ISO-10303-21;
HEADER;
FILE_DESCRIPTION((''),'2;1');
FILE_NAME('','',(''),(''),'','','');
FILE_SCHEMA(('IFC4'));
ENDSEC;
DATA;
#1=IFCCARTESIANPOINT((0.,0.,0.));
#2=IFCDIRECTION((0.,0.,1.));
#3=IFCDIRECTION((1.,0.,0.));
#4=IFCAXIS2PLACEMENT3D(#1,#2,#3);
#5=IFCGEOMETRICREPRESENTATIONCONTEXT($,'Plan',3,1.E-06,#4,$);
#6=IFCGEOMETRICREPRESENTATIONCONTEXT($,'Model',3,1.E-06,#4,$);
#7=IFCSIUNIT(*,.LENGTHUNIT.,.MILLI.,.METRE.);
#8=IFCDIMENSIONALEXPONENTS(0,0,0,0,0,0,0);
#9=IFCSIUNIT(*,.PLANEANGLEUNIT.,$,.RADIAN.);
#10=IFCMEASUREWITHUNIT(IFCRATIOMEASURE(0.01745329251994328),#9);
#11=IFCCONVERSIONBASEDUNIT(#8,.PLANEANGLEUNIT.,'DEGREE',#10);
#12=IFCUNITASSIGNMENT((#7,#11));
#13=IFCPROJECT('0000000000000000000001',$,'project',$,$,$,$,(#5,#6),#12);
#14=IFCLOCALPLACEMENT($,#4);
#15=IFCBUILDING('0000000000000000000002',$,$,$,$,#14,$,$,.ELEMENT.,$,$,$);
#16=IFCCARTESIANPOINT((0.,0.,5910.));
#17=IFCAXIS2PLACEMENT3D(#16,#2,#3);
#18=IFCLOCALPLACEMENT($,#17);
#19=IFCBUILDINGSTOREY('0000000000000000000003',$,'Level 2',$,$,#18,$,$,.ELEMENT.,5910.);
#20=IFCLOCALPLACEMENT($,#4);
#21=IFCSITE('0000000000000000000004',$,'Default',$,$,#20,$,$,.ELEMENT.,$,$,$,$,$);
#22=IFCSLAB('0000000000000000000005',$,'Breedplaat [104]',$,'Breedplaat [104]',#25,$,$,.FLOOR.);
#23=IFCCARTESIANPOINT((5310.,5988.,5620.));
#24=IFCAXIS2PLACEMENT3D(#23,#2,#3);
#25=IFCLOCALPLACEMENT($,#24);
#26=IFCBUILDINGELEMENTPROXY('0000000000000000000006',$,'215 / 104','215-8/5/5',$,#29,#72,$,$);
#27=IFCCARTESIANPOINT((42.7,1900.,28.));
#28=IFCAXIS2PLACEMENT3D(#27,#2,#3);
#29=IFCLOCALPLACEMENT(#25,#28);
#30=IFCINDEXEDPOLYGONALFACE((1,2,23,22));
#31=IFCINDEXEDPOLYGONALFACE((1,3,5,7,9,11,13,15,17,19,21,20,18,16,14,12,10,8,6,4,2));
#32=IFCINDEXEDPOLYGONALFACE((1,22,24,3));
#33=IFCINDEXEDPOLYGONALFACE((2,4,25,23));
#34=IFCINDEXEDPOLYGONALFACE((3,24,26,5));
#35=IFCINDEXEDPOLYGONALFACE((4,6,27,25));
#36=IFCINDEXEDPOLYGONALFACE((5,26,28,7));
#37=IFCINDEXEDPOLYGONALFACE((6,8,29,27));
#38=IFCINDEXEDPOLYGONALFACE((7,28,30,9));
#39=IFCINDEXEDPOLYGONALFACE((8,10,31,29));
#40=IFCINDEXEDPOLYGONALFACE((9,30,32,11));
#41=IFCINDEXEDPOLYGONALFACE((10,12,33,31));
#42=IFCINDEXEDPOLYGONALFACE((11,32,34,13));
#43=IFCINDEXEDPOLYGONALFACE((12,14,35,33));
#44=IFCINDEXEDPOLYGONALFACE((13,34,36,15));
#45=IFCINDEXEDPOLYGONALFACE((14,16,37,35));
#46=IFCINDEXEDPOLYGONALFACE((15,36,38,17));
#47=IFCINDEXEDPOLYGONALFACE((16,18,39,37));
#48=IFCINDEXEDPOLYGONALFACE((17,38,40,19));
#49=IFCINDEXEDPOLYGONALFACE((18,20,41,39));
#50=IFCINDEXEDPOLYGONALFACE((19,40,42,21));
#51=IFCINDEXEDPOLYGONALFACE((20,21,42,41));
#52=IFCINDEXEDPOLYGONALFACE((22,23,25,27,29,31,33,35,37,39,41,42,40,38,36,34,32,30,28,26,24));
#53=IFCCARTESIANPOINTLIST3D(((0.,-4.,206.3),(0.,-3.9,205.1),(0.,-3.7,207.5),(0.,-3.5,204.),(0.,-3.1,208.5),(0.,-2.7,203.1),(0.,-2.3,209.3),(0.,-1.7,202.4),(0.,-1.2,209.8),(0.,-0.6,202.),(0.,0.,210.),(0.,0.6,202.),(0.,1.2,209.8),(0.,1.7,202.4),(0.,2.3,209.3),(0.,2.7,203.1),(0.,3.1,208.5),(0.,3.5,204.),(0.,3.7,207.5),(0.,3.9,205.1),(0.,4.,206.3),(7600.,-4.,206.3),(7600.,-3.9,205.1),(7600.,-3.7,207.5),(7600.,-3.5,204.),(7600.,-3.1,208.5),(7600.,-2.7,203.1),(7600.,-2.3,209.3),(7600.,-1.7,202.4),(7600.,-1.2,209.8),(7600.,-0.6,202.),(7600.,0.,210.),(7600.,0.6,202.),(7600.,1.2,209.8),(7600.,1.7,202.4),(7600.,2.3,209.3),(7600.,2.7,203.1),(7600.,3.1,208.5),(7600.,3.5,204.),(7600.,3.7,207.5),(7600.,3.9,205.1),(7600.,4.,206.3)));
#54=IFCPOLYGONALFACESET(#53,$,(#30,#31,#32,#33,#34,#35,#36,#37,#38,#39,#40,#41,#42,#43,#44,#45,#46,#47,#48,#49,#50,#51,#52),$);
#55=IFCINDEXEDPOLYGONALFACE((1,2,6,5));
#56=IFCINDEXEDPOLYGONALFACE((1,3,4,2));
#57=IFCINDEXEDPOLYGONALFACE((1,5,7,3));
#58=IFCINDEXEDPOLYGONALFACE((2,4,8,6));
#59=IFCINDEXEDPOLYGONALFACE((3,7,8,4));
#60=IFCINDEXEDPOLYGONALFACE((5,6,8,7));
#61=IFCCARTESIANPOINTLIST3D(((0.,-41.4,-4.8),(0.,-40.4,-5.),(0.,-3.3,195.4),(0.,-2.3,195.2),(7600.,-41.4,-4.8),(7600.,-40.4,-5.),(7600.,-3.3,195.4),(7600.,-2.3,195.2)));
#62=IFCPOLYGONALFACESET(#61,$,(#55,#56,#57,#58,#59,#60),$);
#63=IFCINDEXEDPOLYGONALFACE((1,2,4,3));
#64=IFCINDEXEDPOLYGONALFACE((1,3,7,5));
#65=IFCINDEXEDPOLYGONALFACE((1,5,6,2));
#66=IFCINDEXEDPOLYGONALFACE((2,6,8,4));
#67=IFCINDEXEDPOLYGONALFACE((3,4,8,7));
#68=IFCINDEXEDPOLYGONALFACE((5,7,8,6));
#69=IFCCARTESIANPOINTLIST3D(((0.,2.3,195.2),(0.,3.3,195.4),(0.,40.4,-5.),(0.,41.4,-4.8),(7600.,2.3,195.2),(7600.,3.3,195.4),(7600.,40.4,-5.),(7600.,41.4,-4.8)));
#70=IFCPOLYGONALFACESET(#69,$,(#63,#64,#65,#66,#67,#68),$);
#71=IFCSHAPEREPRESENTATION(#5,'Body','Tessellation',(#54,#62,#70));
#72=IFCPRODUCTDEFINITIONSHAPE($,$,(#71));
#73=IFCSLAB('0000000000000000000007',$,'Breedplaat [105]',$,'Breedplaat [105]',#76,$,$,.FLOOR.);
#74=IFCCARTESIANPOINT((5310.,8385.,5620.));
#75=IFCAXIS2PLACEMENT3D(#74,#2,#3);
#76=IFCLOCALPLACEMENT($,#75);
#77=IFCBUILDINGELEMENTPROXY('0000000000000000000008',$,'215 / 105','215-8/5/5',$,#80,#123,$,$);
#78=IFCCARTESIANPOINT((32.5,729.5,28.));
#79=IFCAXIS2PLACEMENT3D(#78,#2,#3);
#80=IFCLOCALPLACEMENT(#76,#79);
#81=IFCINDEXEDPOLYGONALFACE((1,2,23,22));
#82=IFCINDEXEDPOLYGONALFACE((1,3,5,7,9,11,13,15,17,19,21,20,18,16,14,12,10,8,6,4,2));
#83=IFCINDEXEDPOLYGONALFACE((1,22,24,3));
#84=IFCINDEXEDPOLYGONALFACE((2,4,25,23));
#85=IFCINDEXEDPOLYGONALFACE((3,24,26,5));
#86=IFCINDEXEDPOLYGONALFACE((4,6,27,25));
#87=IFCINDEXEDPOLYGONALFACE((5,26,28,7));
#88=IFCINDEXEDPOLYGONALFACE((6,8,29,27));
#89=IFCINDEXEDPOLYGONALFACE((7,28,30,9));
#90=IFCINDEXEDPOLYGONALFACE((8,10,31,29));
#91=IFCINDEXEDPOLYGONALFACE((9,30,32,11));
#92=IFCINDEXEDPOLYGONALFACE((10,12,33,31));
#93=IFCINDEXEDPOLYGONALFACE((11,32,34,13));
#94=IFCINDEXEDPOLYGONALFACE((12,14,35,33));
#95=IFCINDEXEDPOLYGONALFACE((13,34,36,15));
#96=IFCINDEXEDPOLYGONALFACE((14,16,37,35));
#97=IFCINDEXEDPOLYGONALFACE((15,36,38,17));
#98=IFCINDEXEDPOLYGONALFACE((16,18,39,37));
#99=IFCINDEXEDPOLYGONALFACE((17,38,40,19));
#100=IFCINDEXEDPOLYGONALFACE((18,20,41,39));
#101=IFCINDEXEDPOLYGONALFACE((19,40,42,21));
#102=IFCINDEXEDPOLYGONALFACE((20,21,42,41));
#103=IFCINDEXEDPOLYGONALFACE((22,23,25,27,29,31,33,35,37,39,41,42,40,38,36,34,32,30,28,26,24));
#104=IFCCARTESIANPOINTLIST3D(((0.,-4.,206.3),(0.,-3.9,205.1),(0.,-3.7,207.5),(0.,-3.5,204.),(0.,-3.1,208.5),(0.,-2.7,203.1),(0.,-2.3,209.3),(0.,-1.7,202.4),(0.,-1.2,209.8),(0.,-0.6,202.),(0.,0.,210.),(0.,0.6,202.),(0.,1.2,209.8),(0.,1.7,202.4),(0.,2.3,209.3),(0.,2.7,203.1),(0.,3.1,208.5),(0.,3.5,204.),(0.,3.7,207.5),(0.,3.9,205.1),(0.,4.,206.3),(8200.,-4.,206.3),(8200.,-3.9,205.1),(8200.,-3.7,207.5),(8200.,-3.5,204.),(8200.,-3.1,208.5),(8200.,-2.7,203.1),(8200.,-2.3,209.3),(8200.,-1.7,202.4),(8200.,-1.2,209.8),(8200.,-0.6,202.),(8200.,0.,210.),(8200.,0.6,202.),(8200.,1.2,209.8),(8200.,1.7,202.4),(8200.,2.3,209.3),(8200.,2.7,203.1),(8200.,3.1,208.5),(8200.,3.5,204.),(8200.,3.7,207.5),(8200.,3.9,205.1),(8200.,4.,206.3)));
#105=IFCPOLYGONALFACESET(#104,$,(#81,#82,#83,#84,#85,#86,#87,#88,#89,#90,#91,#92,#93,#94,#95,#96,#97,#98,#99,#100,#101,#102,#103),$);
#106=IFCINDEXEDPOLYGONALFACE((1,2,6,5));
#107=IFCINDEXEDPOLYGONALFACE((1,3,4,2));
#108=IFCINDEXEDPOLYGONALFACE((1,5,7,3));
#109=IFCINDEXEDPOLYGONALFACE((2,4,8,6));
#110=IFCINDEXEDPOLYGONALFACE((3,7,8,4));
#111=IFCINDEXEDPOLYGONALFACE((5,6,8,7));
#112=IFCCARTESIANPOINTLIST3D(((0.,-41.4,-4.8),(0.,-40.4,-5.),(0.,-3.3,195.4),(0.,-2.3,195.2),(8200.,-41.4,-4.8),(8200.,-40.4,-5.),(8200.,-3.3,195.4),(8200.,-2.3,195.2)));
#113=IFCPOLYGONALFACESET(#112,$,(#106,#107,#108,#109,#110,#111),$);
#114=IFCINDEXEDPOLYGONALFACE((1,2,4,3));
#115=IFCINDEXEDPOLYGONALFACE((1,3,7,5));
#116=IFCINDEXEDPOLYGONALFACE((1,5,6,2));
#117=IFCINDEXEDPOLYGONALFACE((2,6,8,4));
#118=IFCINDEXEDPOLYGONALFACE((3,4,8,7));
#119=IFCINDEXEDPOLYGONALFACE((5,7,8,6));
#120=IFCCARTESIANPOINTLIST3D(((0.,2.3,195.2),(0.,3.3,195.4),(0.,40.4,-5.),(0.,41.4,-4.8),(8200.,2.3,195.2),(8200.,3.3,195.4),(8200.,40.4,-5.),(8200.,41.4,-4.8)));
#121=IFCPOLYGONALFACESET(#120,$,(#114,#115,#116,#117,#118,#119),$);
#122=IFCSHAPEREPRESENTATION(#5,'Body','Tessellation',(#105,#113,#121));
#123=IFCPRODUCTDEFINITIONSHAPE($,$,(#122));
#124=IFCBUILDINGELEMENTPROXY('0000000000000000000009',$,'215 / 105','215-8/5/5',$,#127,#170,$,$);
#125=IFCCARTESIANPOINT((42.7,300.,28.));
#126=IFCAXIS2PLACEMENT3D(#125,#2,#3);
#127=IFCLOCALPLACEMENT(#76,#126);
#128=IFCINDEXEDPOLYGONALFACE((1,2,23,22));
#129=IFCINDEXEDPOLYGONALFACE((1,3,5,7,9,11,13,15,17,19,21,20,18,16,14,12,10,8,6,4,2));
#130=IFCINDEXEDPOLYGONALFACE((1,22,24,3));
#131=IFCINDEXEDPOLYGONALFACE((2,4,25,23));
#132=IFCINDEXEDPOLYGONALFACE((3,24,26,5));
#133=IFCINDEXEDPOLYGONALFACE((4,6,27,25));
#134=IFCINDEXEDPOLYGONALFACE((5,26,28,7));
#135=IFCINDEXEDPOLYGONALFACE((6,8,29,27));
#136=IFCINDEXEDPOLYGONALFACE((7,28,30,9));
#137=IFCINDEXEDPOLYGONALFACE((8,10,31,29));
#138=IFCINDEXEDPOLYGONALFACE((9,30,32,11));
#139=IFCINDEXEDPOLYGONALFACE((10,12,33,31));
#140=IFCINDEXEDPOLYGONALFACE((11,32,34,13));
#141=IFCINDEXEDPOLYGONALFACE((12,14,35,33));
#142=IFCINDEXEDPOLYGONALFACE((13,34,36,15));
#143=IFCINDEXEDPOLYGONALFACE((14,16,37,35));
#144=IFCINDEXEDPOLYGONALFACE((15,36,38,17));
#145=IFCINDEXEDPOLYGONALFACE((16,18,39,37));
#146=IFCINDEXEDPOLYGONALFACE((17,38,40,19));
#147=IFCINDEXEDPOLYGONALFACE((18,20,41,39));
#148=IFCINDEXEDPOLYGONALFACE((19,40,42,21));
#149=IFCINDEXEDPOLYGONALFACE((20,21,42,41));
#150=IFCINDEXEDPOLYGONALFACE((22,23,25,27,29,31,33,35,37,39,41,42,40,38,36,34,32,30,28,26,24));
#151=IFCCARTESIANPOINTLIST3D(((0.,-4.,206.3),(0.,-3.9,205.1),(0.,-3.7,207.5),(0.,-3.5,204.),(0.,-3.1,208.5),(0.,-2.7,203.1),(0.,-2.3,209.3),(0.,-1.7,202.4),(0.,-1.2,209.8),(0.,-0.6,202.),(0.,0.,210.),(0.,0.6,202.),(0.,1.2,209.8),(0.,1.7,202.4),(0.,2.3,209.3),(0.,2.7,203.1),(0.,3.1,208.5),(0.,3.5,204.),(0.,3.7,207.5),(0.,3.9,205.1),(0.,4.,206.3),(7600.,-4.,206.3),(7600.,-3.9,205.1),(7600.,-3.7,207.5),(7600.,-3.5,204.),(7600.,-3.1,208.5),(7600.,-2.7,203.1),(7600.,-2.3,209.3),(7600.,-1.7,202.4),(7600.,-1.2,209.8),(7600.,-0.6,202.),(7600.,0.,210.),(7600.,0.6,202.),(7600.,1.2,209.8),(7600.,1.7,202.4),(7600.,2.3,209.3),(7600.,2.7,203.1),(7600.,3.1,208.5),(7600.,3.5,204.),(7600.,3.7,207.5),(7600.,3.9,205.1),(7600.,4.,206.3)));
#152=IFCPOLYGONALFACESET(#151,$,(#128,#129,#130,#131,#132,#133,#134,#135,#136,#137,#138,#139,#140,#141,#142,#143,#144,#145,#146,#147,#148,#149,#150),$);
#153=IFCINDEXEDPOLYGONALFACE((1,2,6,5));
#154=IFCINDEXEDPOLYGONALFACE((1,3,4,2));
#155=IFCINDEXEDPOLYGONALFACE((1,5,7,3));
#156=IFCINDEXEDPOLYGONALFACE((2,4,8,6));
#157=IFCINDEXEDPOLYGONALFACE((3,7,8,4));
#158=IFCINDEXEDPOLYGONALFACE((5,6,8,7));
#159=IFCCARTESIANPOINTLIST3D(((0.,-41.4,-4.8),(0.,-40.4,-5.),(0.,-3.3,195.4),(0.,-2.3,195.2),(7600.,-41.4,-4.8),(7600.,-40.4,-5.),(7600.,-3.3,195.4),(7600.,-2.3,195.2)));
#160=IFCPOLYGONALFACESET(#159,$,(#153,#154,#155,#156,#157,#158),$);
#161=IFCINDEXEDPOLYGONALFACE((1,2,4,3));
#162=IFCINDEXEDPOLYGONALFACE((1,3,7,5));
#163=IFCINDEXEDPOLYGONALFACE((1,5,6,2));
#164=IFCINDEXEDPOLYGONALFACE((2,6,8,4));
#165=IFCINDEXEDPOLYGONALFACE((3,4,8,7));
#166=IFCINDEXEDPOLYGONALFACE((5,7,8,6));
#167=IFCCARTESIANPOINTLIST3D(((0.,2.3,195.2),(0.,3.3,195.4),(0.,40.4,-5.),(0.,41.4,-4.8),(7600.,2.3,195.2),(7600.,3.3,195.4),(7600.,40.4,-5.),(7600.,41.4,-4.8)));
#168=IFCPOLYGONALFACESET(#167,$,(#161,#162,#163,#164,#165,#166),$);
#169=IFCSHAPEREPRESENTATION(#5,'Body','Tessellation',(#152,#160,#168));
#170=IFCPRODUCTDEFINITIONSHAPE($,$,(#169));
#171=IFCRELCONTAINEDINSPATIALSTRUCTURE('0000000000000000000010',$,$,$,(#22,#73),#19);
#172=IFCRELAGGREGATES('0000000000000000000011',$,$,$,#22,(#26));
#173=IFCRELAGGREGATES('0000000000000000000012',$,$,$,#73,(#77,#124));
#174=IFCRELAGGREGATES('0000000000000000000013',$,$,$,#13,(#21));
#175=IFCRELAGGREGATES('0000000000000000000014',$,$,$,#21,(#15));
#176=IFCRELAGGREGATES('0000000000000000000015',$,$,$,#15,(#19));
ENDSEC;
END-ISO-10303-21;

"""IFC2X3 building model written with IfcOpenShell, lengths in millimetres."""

from ifc_helpers import new_model, entity, si_unit, converted_unit, frame, origin_with_axes, origin_2d_with_axis, place, context, project, spatial, rectangle, circle, extrude, element, aggregate, save


model = new_model("IFC2X3")

# Units and contexts
plan_context = context("Plan", 3, precision=1e-06, world=origin_with_axes())
model_context = context("Model", 3, precision=1e-06, world=origin_with_axes())
ifc_project = project(units=[si_unit("LENGTHUNIT", "METRE", prefix="MILLI"), converted_unit("PLANEANGLEUNIT", "DEGREE", entity("IfcRatioMeasure", 0.01745329251994328), si_unit("PLANEANGLEUNIT", "RADIAN"), dimensions=[0, 0, 0, 0, 0, 0, 0])], contexts=[plan_context, model_context])

# Site, building, storey
site_placement = place(None, origin_with_axes())
site = spatial("IfcSite", under=ifc_project, at=site_placement, Name="Default", CompositionType="ELEMENT")
building_placement = place(None, origin_with_axes())
building = spatial("IfcBuilding", under=site, at=building_placement, CompositionType="ELEMENT")
storey_placement = place(None, frame((0.0, 0.0, 5910.0), z_axis=(0.0, 0.0, 1.0), x_axis=(1.0, 0.0, 0.0)))
storey = spatial("IfcBuildingStorey", under=building, at=storey_placement, Name="Level 2", CompositionType="ELEMENT", Elevation=5910.0)

# Slabs, building element proxies
slab_1_placement = place(None, frame((5310.0, 5988.0, 5620.0), z_axis=(0.0, 0.0, 1.0), x_axis=(1.0, 0.0, 0.0)))
slab_1 = element("IfcSlab", 1, at=slab_1_placement, inside=storey, Name="Breedplaat [104]", ObjectType="Breedplaat [104]", PredefinedType="FLOOR")
proxy_1_placement = place(slab_1_placement, frame((42.7, 1900.0, 28.0), z_axis=(0.0, 0.0, 1.0), x_axis=(1.0, 0.0, 0.0)))
proxy_1 = element("IfcBuildingElementProxy", 2, at=proxy_1_placement, Name="215 / 104", Description="215-8/5/5", context=plan_context, shape_type="SweptSolid", body=[
    extrude(circle(Radius=4.0, at=origin_2d_with_axis()), frame((0.0, 0.0, 206.0), z_axis=(1.0, 0.0, 0.0), x_axis=(0.0, 0.0, 1.0)), (0.0, 0.0, 1.0), 7600.0),
    extrude(rectangle(XDim=203.8, YDim=1.0, at=origin_2d_with_axis()), frame((0.0, -21.9, 95.2), z_axis=(1.0, 0.0, 0.0), x_axis=(0.0, 0.187112, 0.982339)), (0.0, 0.0, 1.0), 7600.0),
    extrude(rectangle(XDim=203.8, YDim=1.0, at=origin_2d_with_axis()), frame((0.0, 21.9, 95.2), z_axis=(1.0, 0.0, 0.0), x_axis=(0.0, -0.187112, 0.982339)), (0.0, 0.0, 1.0), 7600.0),
])
aggregate(slab_1, [proxy_1])
slab_2_placement = place(None, frame((5310.0, 8385.0, 5620.0), z_axis=(0.0, 0.0, 1.0), x_axis=(1.0, 0.0, 0.0)))
slab_2 = element("IfcSlab", 3, at=slab_2_placement, inside=storey, Name="Breedplaat [105]", ObjectType="Breedplaat [105]", PredefinedType="FLOOR")
proxy_2_placement = place(slab_2_placement, frame((32.5, 729.5, 28.0), z_axis=(0.0, 0.0, 1.0), x_axis=(1.0, 0.0, 0.0)))
proxy_2 = element("IfcBuildingElementProxy", 4, at=proxy_2_placement, Name="215 / 105", Description="215-8/5/5", context=plan_context, shape_type="SweptSolid", body=[
    extrude(circle(Radius=4.0, at=origin_2d_with_axis()), frame((0.0, 0.0, 206.0), z_axis=(1.0, 0.0, 0.0), x_axis=(0.0, 0.0, 1.0)), (0.0, 0.0, 1.0), 8200.0),
    extrude(rectangle(XDim=203.8, YDim=1.0, at=origin_2d_with_axis()), frame((0.0, -21.9, 95.2), z_axis=(1.0, 0.0, 0.0), x_axis=(0.0, 0.187112, 0.982339)), (0.0, 0.0, 1.0), 8200.0),
    extrude(rectangle(XDim=203.8, YDim=1.0, at=origin_2d_with_axis()), frame((0.0, 21.9, 95.2), z_axis=(1.0, 0.0, 0.0), x_axis=(0.0, -0.187112, 0.982339)), (0.0, 0.0, 1.0), 8200.0),
])
proxy_3_placement = place(slab_2_placement, frame((42.7, 300.0, 28.0), z_axis=(0.0, 0.0, 1.0), x_axis=(1.0, 0.0, 0.0)))
proxy_3 = element("IfcBuildingElementProxy", 5, at=proxy_3_placement, Name="215 / 105", Description="215-8/5/5", context=plan_context, shape_type="SweptSolid", body=[
    extrude(circle(Radius=4.0, at=origin_2d_with_axis()), frame((0.0, 0.0, 206.0), z_axis=(1.0, 0.0, 0.0), x_axis=(0.0, 0.0, 1.0)), (0.0, 0.0, 1.0), 7600.0),
    extrude(rectangle(XDim=203.8, YDim=1.0, at=origin_2d_with_axis()), frame((0.0, -21.9, 95.2), z_axis=(1.0, 0.0, 0.0), x_axis=(0.0, 0.187112, 0.982339)), (0.0, 0.0, 1.0), 7600.0),
    extrude(rectangle(XDim=203.8, YDim=1.0, at=origin_2d_with_axis()), frame((0.0, 21.9, 95.2), z_axis=(1.0, 0.0, 0.0), x_axis=(0.0, -0.187112, 0.982339)), (0.0, 0.0, 1.0), 7600.0),
])
aggregate(slab_2, [proxy_2, proxy_3])

save(model, "model.ifc")
